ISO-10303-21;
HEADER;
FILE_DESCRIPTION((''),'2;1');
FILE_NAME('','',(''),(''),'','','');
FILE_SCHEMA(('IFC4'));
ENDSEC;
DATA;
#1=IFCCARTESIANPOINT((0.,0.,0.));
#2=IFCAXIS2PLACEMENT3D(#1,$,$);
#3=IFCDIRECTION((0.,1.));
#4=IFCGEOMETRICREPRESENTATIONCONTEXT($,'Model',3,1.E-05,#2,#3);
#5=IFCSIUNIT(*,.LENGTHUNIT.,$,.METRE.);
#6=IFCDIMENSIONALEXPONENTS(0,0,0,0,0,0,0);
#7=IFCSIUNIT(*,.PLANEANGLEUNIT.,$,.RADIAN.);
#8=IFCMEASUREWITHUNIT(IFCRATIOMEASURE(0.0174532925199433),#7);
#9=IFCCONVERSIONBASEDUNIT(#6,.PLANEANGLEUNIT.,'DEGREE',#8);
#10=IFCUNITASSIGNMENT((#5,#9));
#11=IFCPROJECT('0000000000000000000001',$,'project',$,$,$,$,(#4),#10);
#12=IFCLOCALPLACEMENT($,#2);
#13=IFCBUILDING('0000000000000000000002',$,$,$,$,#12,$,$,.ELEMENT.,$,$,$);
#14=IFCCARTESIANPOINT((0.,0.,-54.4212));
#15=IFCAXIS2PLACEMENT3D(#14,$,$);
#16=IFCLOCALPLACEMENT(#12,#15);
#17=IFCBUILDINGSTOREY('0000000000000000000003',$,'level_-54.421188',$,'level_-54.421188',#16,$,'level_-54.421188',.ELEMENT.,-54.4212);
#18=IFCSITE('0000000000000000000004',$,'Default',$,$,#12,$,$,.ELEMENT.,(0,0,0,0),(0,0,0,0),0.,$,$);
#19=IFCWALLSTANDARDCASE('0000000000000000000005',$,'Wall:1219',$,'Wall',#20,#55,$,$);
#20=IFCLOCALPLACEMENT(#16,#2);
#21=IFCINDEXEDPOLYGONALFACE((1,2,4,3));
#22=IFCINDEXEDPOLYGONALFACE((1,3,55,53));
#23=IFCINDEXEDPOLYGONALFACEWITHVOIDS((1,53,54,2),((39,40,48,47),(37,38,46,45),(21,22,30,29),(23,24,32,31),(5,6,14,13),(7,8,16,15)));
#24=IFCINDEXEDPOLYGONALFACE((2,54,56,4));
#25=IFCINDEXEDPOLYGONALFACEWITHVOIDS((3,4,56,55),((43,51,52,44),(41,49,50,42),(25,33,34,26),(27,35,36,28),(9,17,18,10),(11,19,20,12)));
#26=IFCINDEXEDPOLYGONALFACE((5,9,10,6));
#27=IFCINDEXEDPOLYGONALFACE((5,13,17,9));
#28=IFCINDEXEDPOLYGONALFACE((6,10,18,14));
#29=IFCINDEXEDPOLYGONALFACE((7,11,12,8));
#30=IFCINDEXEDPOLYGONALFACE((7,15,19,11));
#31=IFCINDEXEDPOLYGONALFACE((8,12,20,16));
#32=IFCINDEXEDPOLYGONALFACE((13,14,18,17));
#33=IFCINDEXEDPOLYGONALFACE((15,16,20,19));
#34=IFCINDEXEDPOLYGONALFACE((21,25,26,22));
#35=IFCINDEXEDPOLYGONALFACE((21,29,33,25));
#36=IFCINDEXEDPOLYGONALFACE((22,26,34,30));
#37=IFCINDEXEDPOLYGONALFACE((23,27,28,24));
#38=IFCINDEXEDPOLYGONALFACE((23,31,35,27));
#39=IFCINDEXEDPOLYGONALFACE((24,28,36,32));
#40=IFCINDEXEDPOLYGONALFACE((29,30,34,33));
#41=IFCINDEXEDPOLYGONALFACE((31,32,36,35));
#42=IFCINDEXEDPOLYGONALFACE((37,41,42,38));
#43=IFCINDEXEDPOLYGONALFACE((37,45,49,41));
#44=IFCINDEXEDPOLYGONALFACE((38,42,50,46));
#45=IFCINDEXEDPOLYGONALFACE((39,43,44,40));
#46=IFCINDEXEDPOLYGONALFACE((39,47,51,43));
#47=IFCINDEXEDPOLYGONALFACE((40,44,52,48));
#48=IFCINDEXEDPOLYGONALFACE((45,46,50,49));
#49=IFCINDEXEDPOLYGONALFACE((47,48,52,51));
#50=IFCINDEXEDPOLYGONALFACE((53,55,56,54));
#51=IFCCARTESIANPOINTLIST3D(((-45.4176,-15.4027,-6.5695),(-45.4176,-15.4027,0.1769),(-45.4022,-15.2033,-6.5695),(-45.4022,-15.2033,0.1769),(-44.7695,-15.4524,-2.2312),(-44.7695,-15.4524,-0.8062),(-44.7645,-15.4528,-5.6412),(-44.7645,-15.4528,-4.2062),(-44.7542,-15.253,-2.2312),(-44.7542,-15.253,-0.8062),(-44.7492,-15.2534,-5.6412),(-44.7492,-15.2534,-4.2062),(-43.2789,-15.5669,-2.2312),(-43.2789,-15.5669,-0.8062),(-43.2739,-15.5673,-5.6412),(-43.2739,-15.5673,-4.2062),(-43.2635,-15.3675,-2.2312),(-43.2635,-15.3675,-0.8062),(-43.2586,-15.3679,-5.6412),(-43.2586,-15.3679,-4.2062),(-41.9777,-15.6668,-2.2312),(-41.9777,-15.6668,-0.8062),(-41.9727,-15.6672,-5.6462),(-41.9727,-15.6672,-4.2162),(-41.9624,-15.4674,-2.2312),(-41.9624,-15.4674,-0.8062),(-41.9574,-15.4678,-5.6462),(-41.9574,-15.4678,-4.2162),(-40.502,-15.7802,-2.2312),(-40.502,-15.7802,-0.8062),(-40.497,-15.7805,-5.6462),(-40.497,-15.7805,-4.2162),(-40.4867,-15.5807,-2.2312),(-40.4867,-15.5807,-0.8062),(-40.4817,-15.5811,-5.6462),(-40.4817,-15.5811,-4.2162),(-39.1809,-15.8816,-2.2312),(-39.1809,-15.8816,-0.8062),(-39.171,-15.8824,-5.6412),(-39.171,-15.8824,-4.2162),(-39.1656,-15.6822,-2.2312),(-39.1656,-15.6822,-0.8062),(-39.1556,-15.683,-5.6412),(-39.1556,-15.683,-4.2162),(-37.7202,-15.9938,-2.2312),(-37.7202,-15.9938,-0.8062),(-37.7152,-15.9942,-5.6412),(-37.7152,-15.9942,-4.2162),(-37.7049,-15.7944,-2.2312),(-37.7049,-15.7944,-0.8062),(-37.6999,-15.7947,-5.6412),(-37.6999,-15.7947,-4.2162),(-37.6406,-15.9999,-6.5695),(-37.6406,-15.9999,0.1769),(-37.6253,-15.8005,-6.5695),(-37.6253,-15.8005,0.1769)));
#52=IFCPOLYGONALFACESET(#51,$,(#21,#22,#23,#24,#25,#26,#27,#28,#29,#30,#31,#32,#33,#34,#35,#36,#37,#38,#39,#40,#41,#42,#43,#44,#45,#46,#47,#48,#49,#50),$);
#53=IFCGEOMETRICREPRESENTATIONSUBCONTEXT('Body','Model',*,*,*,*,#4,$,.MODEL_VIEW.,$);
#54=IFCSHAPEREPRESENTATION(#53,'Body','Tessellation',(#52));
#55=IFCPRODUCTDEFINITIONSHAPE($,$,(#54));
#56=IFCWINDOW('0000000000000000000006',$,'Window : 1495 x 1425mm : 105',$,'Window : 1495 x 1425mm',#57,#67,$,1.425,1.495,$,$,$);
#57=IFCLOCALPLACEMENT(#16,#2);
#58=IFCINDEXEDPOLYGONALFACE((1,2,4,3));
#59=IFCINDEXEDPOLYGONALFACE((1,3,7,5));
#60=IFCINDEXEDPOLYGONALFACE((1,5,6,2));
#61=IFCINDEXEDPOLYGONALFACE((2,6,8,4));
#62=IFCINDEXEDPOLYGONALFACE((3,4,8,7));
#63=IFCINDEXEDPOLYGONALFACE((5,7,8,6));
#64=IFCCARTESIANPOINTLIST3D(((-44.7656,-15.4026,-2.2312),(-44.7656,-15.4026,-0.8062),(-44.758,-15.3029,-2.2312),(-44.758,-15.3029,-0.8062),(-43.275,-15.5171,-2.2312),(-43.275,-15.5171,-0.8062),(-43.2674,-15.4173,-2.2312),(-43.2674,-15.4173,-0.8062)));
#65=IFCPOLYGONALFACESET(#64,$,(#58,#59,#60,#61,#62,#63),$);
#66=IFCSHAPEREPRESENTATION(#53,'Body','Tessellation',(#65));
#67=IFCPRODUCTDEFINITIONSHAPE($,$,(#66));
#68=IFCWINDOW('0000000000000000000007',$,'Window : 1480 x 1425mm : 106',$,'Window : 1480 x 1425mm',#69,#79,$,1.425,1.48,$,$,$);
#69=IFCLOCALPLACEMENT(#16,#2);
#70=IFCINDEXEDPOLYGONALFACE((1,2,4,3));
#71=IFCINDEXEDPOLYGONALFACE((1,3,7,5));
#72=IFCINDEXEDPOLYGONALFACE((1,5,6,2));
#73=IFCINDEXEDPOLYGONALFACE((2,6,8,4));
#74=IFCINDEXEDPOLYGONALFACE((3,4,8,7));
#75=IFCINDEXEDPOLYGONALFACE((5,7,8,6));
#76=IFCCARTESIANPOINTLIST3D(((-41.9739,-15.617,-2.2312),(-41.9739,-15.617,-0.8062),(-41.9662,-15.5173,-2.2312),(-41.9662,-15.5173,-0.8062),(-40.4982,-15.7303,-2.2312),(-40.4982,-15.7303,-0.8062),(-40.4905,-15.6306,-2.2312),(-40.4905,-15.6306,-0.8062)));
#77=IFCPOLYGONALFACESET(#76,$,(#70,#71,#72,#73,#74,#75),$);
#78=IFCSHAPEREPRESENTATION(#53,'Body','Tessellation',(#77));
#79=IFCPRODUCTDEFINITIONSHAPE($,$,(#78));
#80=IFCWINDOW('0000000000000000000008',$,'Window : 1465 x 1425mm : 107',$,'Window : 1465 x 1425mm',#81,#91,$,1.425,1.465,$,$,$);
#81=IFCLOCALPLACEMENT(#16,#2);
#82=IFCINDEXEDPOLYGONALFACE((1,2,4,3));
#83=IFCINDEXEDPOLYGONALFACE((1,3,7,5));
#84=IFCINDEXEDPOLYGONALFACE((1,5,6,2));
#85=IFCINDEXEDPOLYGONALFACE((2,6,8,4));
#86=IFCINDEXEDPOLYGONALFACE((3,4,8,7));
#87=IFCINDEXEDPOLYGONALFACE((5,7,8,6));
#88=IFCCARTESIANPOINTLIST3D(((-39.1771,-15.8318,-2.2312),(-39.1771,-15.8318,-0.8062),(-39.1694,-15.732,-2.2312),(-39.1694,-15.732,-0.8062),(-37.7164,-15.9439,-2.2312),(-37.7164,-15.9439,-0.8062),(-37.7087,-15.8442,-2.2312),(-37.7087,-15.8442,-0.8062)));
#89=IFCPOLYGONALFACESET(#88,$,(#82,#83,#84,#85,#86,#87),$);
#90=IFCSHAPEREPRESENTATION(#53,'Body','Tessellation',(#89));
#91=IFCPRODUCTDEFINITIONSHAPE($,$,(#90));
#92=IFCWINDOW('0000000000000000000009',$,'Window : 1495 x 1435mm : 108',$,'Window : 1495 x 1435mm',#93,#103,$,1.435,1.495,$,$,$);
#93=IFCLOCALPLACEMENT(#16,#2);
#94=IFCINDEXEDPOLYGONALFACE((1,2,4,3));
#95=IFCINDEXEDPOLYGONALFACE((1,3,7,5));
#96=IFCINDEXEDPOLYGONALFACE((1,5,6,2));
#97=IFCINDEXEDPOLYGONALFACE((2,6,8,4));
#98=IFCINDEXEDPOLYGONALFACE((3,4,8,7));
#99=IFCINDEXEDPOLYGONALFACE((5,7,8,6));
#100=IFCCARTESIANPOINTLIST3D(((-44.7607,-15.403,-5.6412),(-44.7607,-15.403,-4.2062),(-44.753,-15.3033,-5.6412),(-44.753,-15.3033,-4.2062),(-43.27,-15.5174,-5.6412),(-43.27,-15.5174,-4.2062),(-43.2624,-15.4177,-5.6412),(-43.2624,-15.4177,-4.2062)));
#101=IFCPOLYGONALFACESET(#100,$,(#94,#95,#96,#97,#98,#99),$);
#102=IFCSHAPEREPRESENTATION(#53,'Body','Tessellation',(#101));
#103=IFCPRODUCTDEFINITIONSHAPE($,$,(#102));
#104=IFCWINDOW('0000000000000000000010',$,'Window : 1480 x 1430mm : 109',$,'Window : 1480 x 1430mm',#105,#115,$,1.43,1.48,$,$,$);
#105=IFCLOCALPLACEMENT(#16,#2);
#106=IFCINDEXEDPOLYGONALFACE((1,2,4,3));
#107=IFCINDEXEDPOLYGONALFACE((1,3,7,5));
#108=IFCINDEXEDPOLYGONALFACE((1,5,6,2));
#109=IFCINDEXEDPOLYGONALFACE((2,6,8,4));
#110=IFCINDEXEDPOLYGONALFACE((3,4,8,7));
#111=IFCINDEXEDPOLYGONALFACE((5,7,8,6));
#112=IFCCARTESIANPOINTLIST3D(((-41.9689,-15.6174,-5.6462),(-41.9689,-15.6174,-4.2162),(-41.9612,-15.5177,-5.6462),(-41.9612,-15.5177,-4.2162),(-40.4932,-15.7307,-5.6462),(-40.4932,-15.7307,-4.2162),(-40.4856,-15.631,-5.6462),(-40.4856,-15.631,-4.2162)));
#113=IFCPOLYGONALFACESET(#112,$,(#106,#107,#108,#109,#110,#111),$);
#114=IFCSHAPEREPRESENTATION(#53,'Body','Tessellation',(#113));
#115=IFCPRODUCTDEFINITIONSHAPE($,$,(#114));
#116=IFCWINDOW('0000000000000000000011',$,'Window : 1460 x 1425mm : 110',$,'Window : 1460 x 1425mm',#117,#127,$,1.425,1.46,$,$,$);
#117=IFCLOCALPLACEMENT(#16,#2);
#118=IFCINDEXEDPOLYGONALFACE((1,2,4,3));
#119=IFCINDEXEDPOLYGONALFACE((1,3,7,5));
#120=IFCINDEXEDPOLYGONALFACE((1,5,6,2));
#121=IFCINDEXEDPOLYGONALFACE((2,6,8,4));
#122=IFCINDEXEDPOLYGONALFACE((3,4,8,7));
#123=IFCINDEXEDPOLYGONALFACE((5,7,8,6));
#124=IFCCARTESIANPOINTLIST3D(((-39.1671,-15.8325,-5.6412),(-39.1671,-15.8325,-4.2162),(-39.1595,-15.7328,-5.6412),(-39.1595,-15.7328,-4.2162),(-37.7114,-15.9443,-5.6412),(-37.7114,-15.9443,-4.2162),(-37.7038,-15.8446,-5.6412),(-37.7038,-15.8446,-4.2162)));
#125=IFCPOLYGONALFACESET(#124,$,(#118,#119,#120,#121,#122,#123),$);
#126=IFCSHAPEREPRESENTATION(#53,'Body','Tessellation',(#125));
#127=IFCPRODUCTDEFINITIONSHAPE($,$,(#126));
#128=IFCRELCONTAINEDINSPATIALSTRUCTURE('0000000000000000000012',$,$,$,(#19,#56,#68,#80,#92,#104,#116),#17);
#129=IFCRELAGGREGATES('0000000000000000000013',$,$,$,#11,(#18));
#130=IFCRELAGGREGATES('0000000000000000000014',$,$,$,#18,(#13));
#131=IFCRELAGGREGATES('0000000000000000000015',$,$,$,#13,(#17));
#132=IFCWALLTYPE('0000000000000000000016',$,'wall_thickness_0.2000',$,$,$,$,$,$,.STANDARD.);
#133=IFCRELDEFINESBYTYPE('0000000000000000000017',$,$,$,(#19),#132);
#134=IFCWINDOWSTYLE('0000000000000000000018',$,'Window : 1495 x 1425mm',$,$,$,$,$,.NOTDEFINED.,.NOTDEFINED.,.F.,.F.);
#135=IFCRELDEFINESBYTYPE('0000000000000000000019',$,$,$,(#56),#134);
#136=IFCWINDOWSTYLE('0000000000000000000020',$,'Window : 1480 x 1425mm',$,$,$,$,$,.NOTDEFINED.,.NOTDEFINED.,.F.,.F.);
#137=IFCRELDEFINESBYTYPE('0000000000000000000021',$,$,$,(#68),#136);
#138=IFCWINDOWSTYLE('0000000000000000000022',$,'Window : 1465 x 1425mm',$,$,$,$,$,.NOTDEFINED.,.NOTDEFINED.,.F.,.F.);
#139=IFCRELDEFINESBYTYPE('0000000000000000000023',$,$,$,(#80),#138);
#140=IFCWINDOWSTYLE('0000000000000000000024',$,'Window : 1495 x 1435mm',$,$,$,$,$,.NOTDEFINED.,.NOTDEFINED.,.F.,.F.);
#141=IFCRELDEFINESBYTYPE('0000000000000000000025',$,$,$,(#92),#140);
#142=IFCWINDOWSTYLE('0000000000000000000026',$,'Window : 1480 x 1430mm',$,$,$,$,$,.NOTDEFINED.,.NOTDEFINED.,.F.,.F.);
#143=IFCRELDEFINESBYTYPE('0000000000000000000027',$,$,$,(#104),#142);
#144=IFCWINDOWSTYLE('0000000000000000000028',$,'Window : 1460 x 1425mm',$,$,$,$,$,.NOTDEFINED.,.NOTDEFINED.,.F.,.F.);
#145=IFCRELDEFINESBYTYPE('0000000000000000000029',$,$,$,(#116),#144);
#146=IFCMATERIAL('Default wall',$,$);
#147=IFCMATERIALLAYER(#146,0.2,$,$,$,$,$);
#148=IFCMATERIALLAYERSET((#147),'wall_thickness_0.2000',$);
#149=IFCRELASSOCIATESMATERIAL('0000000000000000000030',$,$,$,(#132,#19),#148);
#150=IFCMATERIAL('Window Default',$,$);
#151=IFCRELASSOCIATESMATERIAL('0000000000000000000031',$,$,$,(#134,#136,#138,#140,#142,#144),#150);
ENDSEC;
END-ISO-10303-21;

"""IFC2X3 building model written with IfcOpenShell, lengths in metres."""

from ifc_helpers import new_model, entity, si_unit, converted_unit, direction, frame, frame_2d, origin, origin_2d_with_axis, place, context, subcontext, project, spatial, polyline, rectangle, outline, extrude, source, transform, mapped, material, layer, layer_set, layer_usage, type_object, type_shapes, element, fill, save


model = new_model("IFC2X3")

# Units and contexts
model_context = context("Model", 3, precision=1e-05, world=origin(), true_north=direction((0.0, 1.0)))
body_context = subcontext(model_context, "Body", "Model", "MODEL_VIEW")
ifc_project = project(units=[si_unit("LENGTHUNIT", "METRE"), converted_unit("PLANEANGLEUNIT", "DEGREE", entity("IfcRatioMeasure", 0.0174532925199433), si_unit("PLANEANGLEUNIT", "RADIAN"), dimensions=[0, 0, 0, 0, 0, 0, 0])], contexts=[model_context])

# Site, building, storey
placement_1 = place(None, origin())
site = spatial("IfcSite", under=ifc_project, at=placement_1, Name="Default", CompositionType="ELEMENT", RefLatitude=(0, 0, 0, 0), RefLongitude=(0, 0, 0, 0), RefElevation=0.0)
building = spatial("IfcBuilding", under=site, at=placement_1, CompositionType="ELEMENT")
storey_placement = place(placement_1, frame((0.0, 0.0, -54.4212)))
storey = spatial("IfcBuildingStorey", under=building, at=storey_placement, Name="level_-54.421188", ObjectType="level_-54.421188", LongName="level_-54.421188", CompositionType="ELEMENT", Elevation=-54.4212)

# Shared definitions
ifc_material_1 = material(Name="Default wall")
ifc_layer = layer(ifc_material_1, 0.2)
ifc_layer_set = layer_set([ifc_layer], Name="wall_thickness_0.2000")
ifc_layer_usage = layer_usage(ifc_layer_set, "AXIS2", "POSITIVE", -0.1)
wall_type = type_object("IfcWallType", Name="wall_thickness_0.2000", PredefinedType="STANDARD", material=ifc_layer_set)

# Wall, openings, windows
placement_2 = place(placement_1, frame((0.0, 0.0, -60.9907)))
wall_1_placement = place(placement_2, frame((-45.4099, -15.303, 0.0), z_axis=(0.0, 0.0, 1.0), x_axis=(0.997064, -0.076569, 0.0)))
wall_1 = element("IfcWallStandardCase", 1, at=wall_1_placement, inside=storey, type_object=wall_type, material=ifc_layer_usage, Name="Wall:1219", ObjectType="Wall", context=body_context, shape_type="SweptSolid", body=[
    extrude(outline(polyline([(7.7999, -0.1), (7.7999, 0.1), (0.0, 0.1), (0.0, -0.1), (7.7999, -0.1)])), origin(), (0.0, 0.0, 1.0), 6.7464),
])
opening_1_placement = place(wall_1_placement, frame((0.65, -0.1, 4.3383)))
opening_1 = element("IfcOpeningElement", 2, at=opening_1_placement, cuts=wall_1, ObjectType="Opening", context=body_context, shape_type="SweptSolid", body=[
    extrude(rectangle(XDim=1.495, YDim=1.425, at=frame_2d((0.7125, 0.7475), x_axis=(0.0, 1.0))), frame((0.0, 0.0, 0.0), z_axis=(0.0, 1.0, 0.0), x_axis=(0.0, 0.0, 1.0)), (0.0, 0.0, 1.0), 0.2),
])
opening_2_placement = place(wall_1_placement, frame((3.45, -0.1, 4.3383)))
opening_2 = element("IfcOpeningElement", 3, at=opening_2_placement, cuts=wall_1, ObjectType="Opening", context=body_context, shape_type="SweptSolid", body=[
    extrude(rectangle(XDim=1.48, YDim=1.425, at=frame_2d((0.7125, 0.74), x_axis=(0.0, 1.0))), frame((0.0, 0.0, 0.0), z_axis=(0.0, 1.0, 0.0), x_axis=(0.0, 0.0, 1.0)), (0.0, 0.0, 1.0), 0.2),
])
opening_3_placement = place(wall_1_placement, frame((6.255, -0.1, 4.3383)))
opening_3 = element("IfcOpeningElement", 4, at=opening_3_placement, cuts=wall_1, ObjectType="Opening", context=body_context, shape_type="SweptSolid", body=[
    extrude(rectangle(XDim=1.465, YDim=1.425, at=frame_2d((0.7125, 0.7325), x_axis=(0.0, 1.0))), frame((0.0, 0.0, 0.0), z_axis=(0.0, 1.0, 0.0), x_axis=(0.0, 0.0, 1.0)), (0.0, 0.0, 1.0), 0.2),
])
opening_4_placement = place(wall_1_placement, frame((0.655, -0.1, 0.9283)))
opening_4 = element("IfcOpeningElement", 5, at=opening_4_placement, cuts=wall_1, ObjectType="Opening", context=body_context, shape_type="SweptSolid", body=[
    extrude(rectangle(XDim=1.495, YDim=1.435, at=frame_2d((0.7175, 0.7475), x_axis=(0.0, 1.0))), frame((0.0, 0.0, 0.0), z_axis=(0.0, 1.0, 0.0), x_axis=(0.0, 0.0, 1.0)), (0.0, 0.0, 1.0), 0.2),
])
opening_5_placement = place(wall_1_placement, frame((3.455, -0.1, 0.9233)))
opening_5 = element("IfcOpeningElement", 6, at=opening_5_placement, cuts=wall_1, ObjectType="Opening", context=body_context, shape_type="SweptSolid", body=[
    extrude(rectangle(XDim=1.48, YDim=1.43, at=frame_2d((0.715, 0.74), x_axis=(0.0, 1.0))), frame((0.0, 0.0, 0.0), z_axis=(0.0, 1.0, 0.0), x_axis=(0.0, 0.0, 1.0)), (0.0, 0.0, 1.0), 0.2),
])
opening_6_placement = place(wall_1_placement, frame((6.265, -0.1, 0.9283)))
opening_6 = element("IfcOpeningElement", 7, at=opening_6_placement, cuts=wall_1, ObjectType="Opening", context=body_context, shape_type="SweptSolid", body=[
    extrude(rectangle(XDim=1.46, YDim=1.425, at=frame_2d((0.7125, 0.73), x_axis=(0.0, 1.0))), frame((0.0, 0.0, 0.0), z_axis=(0.0, 1.0, 0.0), x_axis=(0.0, 0.0, 1.0)), (0.0, 0.0, 1.0), 0.2),
])
ifc_material_2 = material(Name="Window Default")
window_style_1 = type_object("IfcWindowStyle", Name="Window : 1495 x 1425mm", ConstructionType="NOTDEFINED", OperationType="NOTDEFINED", ParameterTakesPrecedence=False, Sizeable=False, material=ifc_material_2)
shared_shape_1 = source(origin(), body_context, "Body", "SweptSolid", [
    extrude(rectangle(XDim=0.1, YDim=1.495, at=origin_2d_with_axis()), frame((0.7475, 0.1, 0.0), z_axis=(0.0, 0.0, 1.0), x_axis=(0.0, 1.0, 0.0)), (0.0, 0.0, 1.0), 1.425),
])
type_shapes(window_style_1, [shared_shape_1])
window_1_placement = place(opening_1_placement, origin())
window_1 = element("IfcWindow", 8, at=window_1_placement, inside=storey, type_object=window_style_1, Name="Window : 1495 x 1425mm : 105", ObjectType="Window : 1495 x 1425mm", OverallHeight=1.425, OverallWidth=1.495, context=body_context, shape_type="MappedRepresentation", body=[
    mapped(shared_shape_1, transform((0.0, 0.0, 0.0), scale=1.0)),
])
fill(opening_1, window_1)
window_style_2 = type_object("IfcWindowStyle", Name="Window : 1480 x 1425mm", ConstructionType="NOTDEFINED", OperationType="NOTDEFINED", ParameterTakesPrecedence=False, Sizeable=False, material=ifc_material_2)
shared_shape_2 = source(origin(), body_context, "Body", "SweptSolid", [
    extrude(rectangle(XDim=0.1, YDim=1.48, at=origin_2d_with_axis()), frame((0.74, 0.1, 0.0), z_axis=(0.0, 0.0, 1.0), x_axis=(0.0, 1.0, 0.0)), (0.0, 0.0, 1.0), 1.425),
])
type_shapes(window_style_2, [shared_shape_2])
window_2_placement = place(opening_2_placement, origin())
window_2 = element("IfcWindow", 9, at=window_2_placement, inside=storey, type_object=window_style_2, Name="Window : 1480 x 1425mm : 106", ObjectType="Window : 1480 x 1425mm", OverallHeight=1.425, OverallWidth=1.48, context=body_context, shape_type="MappedRepresentation", body=[
    mapped(shared_shape_2, transform((0.0, 0.0, 0.0), scale=1.0)),
])
fill(opening_2, window_2)
window_style_3 = type_object("IfcWindowStyle", Name="Window : 1465 x 1425mm", ConstructionType="NOTDEFINED", OperationType="NOTDEFINED", ParameterTakesPrecedence=False, Sizeable=False, material=ifc_material_2)
shared_shape_3 = source(origin(), body_context, "Body", "SweptSolid", [
    extrude(rectangle(XDim=0.1, YDim=1.465, at=origin_2d_with_axis()), frame((0.7325, 0.1, 0.0), z_axis=(0.0, 0.0, 1.0), x_axis=(0.0, 1.0, 0.0)), (0.0, 0.0, 1.0), 1.425),
])
type_shapes(window_style_3, [shared_shape_3])
window_3_placement = place(opening_3_placement, origin())
window_3 = element("IfcWindow", 10, at=window_3_placement, inside=storey, type_object=window_style_3, Name="Window : 1465 x 1425mm : 107", ObjectType="Window : 1465 x 1425mm", OverallHeight=1.425, OverallWidth=1.465, context=body_context, shape_type="MappedRepresentation", body=[
    mapped(shared_shape_3, transform((0.0, 0.0, 0.0), scale=1.0)),
])
fill(opening_3, window_3)
window_style_4 = type_object("IfcWindowStyle", Name="Window : 1495 x 1435mm", ConstructionType="NOTDEFINED", OperationType="NOTDEFINED", ParameterTakesPrecedence=False, Sizeable=False, material=ifc_material_2)
shared_shape_4 = source(origin(), body_context, "Body", "SweptSolid", [
    extrude(rectangle(XDim=0.1, YDim=1.495, at=origin_2d_with_axis()), frame((0.7475, 0.1, 0.0), z_axis=(0.0, 0.0, 1.0), x_axis=(0.0, 1.0, 0.0)), (0.0, 0.0, 1.0), 1.435),
])
type_shapes(window_style_4, [shared_shape_4])
window_4_placement = place(opening_4_placement, origin())
window_4 = element("IfcWindow", 11, at=window_4_placement, inside=storey, type_object=window_style_4, Name="Window : 1495 x 1435mm : 108", ObjectType="Window : 1495 x 1435mm", OverallHeight=1.435, OverallWidth=1.495, context=body_context, shape_type="MappedRepresentation", body=[
    mapped(shared_shape_4, transform((0.0, 0.0, 0.0), scale=1.0)),
])
fill(opening_4, window_4)
window_style_5 = type_object("IfcWindowStyle", Name="Window : 1480 x 1430mm", ConstructionType="NOTDEFINED", OperationType="NOTDEFINED", ParameterTakesPrecedence=False, Sizeable=False, material=ifc_material_2)
shared_shape_5 = source(origin(), body_context, "Body", "SweptSolid", [
    extrude(rectangle(XDim=0.1, YDim=1.48, at=origin_2d_with_axis()), frame((0.74, 0.1, 0.0), z_axis=(0.0, 0.0, 1.0), x_axis=(0.0, 1.0, 0.0)), (0.0, 0.0, 1.0), 1.43),
])
type_shapes(window_style_5, [shared_shape_5])
window_5_placement = place(opening_5_placement, origin())
window_5 = element("IfcWindow", 12, at=window_5_placement, inside=storey, type_object=window_style_5, Name="Window : 1480 x 1430mm : 109", ObjectType="Window : 1480 x 1430mm", OverallHeight=1.43, OverallWidth=1.48, context=body_context, shape_type="MappedRepresentation", body=[
    mapped(shared_shape_5, transform((0.0, 0.0, 0.0), scale=1.0)),
])
fill(opening_5, window_5)
window_style_6 = type_object("IfcWindowStyle", Name="Window : 1460 x 1425mm", ConstructionType="NOTDEFINED", OperationType="NOTDEFINED", ParameterTakesPrecedence=False, Sizeable=False, material=ifc_material_2)
shared_shape_6 = source(origin(), body_context, "Body", "SweptSolid", [
    extrude(rectangle(XDim=0.1, YDim=1.46, at=origin_2d_with_axis()), frame((0.73, 0.1, 0.0), z_axis=(0.0, 0.0, 1.0), x_axis=(0.0, 1.0, 0.0)), (0.0, 0.0, 1.0), 1.425),
])
type_shapes(window_style_6, [shared_shape_6])
window_6_placement = place(opening_6_placement, origin())
window_6 = element("IfcWindow", 13, at=window_6_placement, inside=storey, type_object=window_style_6, Name="Window : 1460 x 1425mm : 110", ObjectType="Window : 1460 x 1425mm", OverallHeight=1.425, OverallWidth=1.46, context=body_context, shape_type="MappedRepresentation", body=[
    mapped(shared_shape_6, transform((0.0, 0.0, 0.0), scale=1.0)),
])
fill(opening_6, window_6)

save(model, "model.ifc")
